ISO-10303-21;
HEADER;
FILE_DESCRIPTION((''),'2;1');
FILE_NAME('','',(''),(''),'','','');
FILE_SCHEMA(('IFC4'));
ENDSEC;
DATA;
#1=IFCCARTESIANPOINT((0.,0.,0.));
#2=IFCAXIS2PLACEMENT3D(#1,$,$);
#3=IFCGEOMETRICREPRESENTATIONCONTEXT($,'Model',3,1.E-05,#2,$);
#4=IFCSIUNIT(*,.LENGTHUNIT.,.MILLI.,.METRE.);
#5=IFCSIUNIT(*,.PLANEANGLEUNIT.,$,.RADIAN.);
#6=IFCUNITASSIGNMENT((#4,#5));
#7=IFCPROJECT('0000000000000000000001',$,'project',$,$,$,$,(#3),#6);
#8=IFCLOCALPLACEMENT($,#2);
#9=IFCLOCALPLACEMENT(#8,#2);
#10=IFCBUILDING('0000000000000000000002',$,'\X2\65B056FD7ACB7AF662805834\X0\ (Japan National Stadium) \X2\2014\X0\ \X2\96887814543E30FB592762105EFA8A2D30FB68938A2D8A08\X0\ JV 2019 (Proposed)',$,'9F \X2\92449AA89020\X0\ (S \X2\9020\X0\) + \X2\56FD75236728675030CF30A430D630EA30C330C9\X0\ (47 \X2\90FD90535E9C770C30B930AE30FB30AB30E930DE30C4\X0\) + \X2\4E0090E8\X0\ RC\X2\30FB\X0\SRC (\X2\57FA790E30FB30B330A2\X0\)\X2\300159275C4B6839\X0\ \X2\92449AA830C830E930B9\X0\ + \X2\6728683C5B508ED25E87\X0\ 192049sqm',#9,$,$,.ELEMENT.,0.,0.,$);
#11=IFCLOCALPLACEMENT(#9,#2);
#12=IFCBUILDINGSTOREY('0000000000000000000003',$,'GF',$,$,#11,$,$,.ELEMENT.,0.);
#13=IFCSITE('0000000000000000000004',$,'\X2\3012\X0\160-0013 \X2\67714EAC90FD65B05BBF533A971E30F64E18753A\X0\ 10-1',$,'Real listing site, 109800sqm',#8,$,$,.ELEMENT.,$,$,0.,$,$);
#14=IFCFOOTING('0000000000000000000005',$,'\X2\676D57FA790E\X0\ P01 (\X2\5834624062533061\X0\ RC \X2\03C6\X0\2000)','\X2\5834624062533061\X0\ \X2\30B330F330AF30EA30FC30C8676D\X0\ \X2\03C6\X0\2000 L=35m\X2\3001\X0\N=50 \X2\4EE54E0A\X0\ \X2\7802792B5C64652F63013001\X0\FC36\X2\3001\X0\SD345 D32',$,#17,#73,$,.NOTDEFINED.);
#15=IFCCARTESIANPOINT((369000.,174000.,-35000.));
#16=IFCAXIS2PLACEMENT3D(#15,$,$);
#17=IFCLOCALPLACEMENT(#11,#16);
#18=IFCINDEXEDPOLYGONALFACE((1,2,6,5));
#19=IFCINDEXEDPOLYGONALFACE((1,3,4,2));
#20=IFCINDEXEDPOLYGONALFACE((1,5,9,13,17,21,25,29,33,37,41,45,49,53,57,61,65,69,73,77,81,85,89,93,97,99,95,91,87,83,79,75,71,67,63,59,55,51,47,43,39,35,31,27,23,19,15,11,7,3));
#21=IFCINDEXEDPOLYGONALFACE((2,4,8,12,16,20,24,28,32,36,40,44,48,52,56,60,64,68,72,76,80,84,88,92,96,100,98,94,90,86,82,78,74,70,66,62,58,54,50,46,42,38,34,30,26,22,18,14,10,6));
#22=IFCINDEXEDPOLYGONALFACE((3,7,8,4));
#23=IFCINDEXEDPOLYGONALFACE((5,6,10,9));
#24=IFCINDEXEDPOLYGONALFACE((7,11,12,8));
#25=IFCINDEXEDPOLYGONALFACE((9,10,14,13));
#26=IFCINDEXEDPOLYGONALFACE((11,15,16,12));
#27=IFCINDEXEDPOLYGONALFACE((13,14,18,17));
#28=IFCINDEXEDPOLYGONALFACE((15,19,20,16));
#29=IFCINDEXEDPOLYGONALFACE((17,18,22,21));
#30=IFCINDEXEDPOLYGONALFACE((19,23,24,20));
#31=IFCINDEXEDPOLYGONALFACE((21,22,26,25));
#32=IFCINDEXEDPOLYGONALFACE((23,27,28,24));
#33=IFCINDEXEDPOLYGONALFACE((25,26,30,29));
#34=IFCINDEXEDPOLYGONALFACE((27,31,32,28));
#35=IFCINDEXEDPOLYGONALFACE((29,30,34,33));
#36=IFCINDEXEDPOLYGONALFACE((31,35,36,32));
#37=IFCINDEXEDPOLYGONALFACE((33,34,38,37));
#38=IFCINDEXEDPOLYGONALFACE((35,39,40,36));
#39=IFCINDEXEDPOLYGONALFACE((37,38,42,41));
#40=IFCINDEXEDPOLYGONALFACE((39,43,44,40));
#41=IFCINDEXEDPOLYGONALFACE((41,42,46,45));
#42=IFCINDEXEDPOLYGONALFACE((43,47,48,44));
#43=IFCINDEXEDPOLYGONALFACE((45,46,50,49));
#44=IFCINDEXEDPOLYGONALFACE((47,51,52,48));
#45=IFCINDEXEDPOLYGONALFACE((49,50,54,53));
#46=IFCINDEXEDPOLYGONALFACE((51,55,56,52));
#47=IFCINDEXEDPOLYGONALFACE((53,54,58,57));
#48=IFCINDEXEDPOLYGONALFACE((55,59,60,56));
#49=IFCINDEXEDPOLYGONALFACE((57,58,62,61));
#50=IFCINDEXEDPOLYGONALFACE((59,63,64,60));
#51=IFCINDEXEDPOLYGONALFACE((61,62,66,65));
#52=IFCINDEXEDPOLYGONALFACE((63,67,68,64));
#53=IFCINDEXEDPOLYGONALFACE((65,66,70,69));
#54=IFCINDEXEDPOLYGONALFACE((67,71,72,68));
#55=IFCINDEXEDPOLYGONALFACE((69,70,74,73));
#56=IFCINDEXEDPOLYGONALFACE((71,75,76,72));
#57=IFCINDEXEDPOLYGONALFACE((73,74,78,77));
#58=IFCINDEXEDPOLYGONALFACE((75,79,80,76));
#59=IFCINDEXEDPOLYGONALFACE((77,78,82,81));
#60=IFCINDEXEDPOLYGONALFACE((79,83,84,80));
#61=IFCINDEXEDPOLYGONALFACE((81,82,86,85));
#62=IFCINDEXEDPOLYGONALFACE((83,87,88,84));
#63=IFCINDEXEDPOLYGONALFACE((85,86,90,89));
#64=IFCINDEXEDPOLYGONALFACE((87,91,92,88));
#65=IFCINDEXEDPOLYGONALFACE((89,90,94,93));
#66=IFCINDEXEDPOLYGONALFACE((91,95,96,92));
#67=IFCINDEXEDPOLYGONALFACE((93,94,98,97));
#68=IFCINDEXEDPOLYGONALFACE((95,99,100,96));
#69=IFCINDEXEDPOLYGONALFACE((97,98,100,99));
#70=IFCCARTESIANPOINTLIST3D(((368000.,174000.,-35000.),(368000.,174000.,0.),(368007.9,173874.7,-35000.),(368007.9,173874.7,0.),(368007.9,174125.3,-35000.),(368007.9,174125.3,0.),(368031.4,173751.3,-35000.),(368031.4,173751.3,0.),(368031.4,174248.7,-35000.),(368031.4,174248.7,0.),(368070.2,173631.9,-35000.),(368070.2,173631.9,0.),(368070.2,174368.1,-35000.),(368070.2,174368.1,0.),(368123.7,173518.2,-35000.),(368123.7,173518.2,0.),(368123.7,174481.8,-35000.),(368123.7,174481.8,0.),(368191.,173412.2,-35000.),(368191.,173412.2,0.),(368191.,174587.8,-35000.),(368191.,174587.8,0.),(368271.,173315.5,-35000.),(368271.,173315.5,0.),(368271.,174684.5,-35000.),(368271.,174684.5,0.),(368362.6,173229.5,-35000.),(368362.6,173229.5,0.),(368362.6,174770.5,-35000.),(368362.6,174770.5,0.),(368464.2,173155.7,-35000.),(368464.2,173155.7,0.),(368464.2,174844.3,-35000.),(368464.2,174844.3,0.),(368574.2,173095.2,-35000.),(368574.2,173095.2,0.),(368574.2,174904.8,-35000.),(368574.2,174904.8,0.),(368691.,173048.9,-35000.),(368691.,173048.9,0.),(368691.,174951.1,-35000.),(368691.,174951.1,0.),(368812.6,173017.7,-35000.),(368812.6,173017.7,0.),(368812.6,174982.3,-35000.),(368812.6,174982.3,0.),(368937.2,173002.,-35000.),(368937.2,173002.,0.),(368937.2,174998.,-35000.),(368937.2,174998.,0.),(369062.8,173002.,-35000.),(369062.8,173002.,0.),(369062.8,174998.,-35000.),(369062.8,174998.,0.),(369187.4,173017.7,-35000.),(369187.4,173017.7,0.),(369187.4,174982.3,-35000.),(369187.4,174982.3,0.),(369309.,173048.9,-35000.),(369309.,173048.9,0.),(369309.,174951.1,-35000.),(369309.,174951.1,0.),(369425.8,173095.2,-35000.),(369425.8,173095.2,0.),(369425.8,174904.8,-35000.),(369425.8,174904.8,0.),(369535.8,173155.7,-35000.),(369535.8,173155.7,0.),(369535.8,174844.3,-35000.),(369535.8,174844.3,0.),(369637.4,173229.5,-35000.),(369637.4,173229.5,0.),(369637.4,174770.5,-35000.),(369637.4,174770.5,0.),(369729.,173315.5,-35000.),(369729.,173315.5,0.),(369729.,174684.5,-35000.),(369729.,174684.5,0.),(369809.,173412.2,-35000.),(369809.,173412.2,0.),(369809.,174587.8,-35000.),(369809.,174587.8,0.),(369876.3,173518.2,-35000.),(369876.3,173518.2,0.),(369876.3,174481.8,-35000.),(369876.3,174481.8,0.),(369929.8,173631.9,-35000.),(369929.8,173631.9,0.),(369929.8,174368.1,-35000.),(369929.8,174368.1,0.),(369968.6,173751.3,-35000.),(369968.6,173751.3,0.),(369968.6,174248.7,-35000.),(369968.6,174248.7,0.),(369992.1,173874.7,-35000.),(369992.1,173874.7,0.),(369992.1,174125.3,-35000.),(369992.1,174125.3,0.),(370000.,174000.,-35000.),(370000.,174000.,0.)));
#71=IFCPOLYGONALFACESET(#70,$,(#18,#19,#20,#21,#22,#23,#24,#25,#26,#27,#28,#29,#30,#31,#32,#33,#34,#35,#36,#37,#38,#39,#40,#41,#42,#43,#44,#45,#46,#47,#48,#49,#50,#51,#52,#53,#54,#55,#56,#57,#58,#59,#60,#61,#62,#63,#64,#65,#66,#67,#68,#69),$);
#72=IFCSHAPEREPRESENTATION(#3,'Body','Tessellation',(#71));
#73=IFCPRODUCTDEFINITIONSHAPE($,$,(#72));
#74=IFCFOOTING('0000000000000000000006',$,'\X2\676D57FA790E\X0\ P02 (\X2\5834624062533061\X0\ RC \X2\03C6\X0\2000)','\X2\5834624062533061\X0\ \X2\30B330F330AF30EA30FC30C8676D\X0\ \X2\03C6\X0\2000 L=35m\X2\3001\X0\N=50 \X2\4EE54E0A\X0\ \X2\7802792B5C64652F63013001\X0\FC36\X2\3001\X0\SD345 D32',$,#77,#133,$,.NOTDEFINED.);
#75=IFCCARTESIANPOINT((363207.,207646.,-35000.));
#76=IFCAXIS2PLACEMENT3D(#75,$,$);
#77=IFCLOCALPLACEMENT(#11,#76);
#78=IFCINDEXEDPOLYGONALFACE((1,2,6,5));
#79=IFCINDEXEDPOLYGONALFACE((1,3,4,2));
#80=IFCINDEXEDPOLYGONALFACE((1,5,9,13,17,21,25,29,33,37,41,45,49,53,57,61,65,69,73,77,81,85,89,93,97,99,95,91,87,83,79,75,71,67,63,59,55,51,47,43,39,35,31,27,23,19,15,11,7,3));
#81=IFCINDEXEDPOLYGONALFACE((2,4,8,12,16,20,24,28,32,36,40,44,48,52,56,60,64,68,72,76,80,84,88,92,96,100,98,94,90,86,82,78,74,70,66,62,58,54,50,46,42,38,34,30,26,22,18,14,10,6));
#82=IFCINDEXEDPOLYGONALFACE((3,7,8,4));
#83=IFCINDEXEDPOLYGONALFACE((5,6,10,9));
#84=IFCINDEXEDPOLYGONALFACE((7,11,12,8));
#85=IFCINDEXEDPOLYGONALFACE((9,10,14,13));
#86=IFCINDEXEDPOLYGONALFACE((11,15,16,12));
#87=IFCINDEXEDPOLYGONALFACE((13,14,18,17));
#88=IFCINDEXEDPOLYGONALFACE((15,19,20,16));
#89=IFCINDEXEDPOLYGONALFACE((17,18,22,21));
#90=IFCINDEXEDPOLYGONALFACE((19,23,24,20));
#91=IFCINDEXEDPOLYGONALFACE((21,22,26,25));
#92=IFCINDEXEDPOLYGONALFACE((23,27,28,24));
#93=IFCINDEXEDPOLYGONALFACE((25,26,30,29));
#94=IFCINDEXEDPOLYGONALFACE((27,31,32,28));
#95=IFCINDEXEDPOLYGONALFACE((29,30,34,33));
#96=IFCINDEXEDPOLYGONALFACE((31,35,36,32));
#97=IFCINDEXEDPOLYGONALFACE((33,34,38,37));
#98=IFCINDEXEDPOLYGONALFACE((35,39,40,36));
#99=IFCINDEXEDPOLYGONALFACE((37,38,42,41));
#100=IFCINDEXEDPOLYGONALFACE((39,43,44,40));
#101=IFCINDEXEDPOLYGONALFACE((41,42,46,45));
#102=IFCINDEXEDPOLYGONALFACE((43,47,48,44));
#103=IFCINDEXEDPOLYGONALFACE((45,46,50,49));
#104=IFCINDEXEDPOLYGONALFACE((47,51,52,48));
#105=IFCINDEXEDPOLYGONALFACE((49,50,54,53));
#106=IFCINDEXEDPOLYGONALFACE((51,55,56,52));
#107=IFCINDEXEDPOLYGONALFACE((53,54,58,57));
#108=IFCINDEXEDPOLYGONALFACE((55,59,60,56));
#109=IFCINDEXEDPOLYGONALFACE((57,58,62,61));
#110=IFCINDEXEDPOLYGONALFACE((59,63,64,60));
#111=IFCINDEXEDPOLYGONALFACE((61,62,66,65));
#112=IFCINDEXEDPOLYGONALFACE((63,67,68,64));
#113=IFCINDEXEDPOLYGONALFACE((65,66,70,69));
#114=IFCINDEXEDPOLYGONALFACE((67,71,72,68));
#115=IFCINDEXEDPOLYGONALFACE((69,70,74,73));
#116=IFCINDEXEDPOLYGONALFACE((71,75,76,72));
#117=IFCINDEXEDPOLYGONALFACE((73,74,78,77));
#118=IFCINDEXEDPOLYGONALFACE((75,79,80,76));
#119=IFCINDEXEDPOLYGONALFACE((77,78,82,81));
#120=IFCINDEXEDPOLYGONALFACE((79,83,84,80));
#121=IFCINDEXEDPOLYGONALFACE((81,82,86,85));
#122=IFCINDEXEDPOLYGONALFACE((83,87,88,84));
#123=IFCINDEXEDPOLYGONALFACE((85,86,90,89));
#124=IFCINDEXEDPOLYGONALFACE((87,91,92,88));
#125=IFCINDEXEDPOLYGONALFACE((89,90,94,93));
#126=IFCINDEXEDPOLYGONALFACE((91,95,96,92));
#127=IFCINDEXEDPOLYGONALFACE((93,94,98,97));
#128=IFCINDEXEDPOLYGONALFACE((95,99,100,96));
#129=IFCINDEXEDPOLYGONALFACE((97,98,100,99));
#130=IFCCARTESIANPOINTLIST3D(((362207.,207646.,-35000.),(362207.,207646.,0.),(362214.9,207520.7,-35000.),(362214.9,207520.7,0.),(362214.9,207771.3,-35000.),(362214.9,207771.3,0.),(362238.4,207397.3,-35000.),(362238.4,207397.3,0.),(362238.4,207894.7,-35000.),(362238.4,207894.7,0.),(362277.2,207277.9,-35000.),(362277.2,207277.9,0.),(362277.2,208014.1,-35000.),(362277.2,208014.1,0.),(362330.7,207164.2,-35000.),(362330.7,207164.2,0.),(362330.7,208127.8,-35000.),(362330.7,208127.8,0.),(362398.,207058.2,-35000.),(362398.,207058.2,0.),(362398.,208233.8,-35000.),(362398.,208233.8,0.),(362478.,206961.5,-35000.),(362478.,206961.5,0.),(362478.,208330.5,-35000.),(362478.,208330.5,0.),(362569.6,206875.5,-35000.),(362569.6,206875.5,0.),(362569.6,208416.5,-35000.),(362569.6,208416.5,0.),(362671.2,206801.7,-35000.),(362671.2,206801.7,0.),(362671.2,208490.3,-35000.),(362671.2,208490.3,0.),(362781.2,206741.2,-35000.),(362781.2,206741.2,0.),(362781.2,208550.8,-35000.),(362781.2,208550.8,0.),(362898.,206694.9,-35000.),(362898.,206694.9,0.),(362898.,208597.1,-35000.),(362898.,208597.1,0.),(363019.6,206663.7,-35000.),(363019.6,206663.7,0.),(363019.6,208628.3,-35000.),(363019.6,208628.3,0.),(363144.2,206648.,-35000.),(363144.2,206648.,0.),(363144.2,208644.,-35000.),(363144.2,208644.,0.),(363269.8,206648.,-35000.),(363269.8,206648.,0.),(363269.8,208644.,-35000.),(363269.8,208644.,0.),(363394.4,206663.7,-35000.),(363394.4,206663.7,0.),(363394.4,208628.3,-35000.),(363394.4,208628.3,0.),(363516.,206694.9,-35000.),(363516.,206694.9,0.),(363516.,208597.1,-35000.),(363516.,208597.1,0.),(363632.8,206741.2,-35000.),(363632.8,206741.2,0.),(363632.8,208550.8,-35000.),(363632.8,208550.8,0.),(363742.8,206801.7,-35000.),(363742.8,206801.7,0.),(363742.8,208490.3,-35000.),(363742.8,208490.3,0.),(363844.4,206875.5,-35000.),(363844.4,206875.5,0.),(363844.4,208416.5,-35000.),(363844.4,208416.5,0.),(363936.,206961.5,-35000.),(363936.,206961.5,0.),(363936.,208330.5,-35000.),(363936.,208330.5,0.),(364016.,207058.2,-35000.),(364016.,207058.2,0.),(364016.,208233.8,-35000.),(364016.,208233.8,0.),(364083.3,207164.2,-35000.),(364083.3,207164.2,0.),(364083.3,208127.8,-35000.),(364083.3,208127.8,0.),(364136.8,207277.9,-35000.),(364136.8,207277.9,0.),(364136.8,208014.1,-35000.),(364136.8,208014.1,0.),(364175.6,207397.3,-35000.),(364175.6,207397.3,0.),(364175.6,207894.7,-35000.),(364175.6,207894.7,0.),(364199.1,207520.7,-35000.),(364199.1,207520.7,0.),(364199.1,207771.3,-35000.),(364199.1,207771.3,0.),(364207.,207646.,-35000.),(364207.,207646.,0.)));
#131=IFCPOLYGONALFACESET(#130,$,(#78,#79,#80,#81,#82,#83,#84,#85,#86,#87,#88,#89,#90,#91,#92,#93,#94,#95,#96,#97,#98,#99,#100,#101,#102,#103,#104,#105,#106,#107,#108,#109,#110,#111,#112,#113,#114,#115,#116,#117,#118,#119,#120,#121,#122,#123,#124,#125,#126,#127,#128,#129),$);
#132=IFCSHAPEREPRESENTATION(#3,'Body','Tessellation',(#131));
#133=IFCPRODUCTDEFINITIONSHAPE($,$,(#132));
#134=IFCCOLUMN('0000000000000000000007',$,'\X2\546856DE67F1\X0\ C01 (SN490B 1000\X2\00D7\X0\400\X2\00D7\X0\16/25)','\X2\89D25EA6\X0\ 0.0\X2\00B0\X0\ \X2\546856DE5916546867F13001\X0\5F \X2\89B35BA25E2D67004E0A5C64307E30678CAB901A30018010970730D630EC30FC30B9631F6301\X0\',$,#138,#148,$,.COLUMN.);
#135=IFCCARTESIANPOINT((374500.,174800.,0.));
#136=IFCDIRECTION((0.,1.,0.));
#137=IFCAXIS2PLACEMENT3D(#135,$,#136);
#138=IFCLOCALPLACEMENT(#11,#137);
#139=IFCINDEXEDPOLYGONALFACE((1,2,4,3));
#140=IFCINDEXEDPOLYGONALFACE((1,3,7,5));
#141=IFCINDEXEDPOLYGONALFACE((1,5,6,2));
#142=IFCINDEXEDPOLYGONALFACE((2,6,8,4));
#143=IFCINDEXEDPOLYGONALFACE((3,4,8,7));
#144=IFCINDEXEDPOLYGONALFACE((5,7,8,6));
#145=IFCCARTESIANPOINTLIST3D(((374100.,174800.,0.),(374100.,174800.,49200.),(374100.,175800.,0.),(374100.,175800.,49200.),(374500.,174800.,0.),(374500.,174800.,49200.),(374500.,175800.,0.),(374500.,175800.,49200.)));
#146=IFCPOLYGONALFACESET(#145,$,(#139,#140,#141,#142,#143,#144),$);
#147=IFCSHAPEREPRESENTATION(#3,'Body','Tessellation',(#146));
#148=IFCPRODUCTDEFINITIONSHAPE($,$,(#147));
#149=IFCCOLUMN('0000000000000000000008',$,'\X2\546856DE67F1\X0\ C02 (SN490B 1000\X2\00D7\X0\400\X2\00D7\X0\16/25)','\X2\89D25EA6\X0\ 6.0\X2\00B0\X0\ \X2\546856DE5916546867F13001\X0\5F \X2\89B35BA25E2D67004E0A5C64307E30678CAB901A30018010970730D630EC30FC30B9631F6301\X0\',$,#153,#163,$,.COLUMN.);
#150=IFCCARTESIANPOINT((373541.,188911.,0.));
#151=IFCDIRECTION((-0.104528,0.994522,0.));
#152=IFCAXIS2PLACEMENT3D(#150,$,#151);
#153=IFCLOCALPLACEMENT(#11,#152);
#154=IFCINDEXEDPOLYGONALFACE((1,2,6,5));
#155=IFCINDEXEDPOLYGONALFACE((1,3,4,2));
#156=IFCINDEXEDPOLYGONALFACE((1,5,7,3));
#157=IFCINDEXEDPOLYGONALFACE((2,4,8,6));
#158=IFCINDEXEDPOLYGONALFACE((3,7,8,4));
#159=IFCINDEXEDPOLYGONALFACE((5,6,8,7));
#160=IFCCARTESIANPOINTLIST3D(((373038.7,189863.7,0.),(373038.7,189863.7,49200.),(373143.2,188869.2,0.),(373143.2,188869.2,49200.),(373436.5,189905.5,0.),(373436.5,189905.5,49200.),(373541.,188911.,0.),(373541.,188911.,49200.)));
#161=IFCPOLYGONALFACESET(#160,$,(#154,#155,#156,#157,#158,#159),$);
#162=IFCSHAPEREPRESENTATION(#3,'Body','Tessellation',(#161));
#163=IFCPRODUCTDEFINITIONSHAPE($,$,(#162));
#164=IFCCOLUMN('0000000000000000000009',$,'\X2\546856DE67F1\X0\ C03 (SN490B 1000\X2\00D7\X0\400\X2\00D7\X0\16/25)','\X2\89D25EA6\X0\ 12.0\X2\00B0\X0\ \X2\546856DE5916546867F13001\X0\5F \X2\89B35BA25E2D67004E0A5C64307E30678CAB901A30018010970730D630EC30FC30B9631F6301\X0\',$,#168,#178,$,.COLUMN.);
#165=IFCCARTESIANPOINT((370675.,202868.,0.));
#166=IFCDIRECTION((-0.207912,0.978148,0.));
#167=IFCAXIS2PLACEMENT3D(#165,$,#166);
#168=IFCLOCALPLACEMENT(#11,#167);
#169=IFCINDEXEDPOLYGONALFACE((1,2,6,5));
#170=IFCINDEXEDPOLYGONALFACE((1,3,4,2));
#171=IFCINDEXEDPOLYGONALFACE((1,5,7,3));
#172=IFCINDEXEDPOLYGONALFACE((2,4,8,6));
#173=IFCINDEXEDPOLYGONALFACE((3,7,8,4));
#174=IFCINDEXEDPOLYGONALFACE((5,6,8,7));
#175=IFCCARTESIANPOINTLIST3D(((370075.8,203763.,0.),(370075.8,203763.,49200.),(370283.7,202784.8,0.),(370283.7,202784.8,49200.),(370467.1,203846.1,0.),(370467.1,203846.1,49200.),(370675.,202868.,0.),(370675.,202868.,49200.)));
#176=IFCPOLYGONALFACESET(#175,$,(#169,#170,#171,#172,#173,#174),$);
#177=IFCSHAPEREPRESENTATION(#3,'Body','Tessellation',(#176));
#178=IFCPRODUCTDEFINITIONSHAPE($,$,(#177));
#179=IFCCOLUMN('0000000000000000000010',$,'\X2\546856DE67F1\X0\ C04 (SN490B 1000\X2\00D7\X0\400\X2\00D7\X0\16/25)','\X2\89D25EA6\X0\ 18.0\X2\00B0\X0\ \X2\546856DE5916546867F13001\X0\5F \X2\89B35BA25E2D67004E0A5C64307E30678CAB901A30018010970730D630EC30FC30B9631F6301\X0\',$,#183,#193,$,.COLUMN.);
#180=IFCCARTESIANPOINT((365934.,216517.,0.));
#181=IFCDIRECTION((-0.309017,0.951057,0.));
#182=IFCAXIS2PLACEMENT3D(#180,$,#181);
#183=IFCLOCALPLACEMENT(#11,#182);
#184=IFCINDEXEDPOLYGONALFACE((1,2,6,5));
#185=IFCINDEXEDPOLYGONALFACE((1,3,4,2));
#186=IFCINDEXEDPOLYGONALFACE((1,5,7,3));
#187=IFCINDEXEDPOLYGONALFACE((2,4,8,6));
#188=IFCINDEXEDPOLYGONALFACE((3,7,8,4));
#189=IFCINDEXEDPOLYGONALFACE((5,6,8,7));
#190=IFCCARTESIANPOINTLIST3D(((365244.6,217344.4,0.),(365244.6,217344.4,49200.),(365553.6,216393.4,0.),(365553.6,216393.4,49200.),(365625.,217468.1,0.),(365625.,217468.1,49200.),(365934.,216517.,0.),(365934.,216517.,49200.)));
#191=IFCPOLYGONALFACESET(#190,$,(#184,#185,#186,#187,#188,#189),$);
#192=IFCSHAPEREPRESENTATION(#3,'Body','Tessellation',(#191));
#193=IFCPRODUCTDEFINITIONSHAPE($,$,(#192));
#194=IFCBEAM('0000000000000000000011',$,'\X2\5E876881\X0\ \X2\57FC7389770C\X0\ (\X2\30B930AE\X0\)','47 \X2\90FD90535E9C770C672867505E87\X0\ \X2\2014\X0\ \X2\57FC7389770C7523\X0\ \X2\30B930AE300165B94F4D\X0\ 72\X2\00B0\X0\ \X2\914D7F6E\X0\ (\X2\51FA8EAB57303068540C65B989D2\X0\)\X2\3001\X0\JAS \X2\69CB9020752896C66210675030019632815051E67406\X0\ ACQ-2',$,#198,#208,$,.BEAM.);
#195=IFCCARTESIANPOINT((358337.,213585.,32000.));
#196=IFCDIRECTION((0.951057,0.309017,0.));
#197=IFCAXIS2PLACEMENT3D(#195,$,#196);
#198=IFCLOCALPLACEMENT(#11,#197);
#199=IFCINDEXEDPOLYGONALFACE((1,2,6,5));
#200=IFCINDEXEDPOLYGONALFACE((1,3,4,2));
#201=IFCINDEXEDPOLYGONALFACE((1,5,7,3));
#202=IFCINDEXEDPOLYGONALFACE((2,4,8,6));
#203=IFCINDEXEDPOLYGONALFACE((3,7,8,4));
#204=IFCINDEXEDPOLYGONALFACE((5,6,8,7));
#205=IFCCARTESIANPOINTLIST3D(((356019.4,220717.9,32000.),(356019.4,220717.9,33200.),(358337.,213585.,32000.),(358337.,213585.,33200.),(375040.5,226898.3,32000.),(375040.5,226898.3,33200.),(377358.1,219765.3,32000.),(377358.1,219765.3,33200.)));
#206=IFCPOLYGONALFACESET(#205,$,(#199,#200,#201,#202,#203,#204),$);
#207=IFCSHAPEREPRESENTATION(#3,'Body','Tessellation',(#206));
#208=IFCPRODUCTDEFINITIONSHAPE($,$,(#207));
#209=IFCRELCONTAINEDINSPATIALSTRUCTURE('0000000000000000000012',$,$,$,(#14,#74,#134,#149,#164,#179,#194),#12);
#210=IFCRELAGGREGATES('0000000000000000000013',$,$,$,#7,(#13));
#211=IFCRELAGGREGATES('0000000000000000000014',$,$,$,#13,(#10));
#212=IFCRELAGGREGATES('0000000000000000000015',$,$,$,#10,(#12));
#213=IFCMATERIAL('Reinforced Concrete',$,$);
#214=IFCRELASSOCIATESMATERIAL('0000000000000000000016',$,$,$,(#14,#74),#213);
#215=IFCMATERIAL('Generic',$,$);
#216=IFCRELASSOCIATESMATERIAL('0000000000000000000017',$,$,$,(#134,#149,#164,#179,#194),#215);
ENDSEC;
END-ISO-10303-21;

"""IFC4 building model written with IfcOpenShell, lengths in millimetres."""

from ifc_helpers import new_model, si_unit, frame, frame_2d, origin, origin_2d, place, context, project, spatial, rectangle, circle, extrude, material, element, save


model = new_model("IFC4")

# Units and contexts
model_context = context("Model", 3, precision=1e-05, world=origin())
ifc_project = project(units=[si_unit("LENGTHUNIT", "METRE", prefix="MILLI"), si_unit("PLANEANGLEUNIT", "RADIAN")], contexts=[model_context])

# Site, building, storey
site_placement = place(None, origin())
site = spatial("IfcSite", under=ifc_project, at=site_placement, Name="〒160-0013 東京都新宿区霞ヶ丘町 10-1", ObjectType="Real listing site, 109800sqm", CompositionType="ELEMENT", RefElevation=0.0)
building_placement = place(site_placement, origin())
building = spatial("IfcBuilding", under=site, at=building_placement, Name="新国立競技場 (Japan National Stadium) — 隈研吾・大成建設・梓設計 JV 2019 (Proposed)", ObjectType="9F 鉄骨造 (S 造) + 国産木材ハイブリッド (47 都道府県スギ・カラマツ) + 一部 RC・SRC (基礎・コア)、大屋根 鉄骨トラス + 木格子軒庇 192049sqm", CompositionType="ELEMENT", ElevationOfRefHeight=0.0, ElevationOfTerrain=0.0)
storey_placement = place(building_placement, origin())
storey = spatial("IfcBuildingStorey", under=building, at=storey_placement, Name="GF", CompositionType="ELEMENT", Elevation=0.0)

# Footings
ifc_material_1 = material(Name="Reinforced Concrete")
footing_1_placement = place(storey_placement, frame((369000.0, 174000.0, -35000.0)))
element("IfcFooting", 1, at=footing_1_placement, inside=storey, material=ifc_material_1, Name="杭基礎 P01 (場所打ち RC φ2000)", Description="場所打ち コンクリート杭 φ2000 L=35m、N=50 以上 砂礫層支持、FC36、SD345 D32", PredefinedType="NOTDEFINED", context=model_context, shape_type="SweptSolid", body=[
    extrude(circle(Radius=1000.0, at=origin_2d()), frame((369000.0, 174000.0, -35000.0)), (0.0, 0.0, 1.0), 35000.0),
])
footing_2_placement = place(storey_placement, frame((363207.0, 207646.0, -35000.0)))
element("IfcFooting", 2, at=footing_2_placement, inside=storey, material=ifc_material_1, Name="杭基礎 P02 (場所打ち RC φ2000)", Description="場所打ち コンクリート杭 φ2000 L=35m、N=50 以上 砂礫層支持、FC36、SD345 D32", PredefinedType="NOTDEFINED", context=model_context, shape_type="SweptSolid", body=[
    extrude(circle(Radius=1000.0, at=origin_2d()), frame((363207.0, 207646.0, -35000.0)), (0.0, 0.0, 1.0), 35000.0),
])

# Columns
ifc_material_2 = material(Name="Generic")
column_1_placement = place(storey_placement, frame((374500.0, 174800.0, 0.0), x_axis=(0.0, 1.0, 0.0)))
element("IfcColumn", 3, at=column_1_placement, inside=storey, material=ifc_material_2, Name="周回柱 C01 (SN490B 1000×400×16/25)", Description="角度 0.0° 周回外周柱、5F 観客席最上層まで貫通、耐震ブレース挟持", PredefinedType="COLUMN", context=model_context, shape_type="SweptSolid", body=[
    extrude(rectangle(XDim=1000.0, YDim=400.0, at=frame_2d((500.0, 200.0))), frame((374500.0, 174800.0, 0.0), x_axis=(0.0, 1.0, 0.0)), (0.0, 0.0, 1.0), 49200.0),
])
column_2_placement = place(storey_placement, frame((373541.0, 188911.0, 0.0), x_axis=(-0.104528, 0.994522, 0.0)))
element("IfcColumn", 4, at=column_2_placement, inside=storey, material=ifc_material_2, Name="周回柱 C02 (SN490B 1000×400×16/25)", Description="角度 6.0° 周回外周柱、5F 観客席最上層まで貫通、耐震ブレース挟持", PredefinedType="COLUMN", context=model_context, shape_type="SweptSolid", body=[
    extrude(rectangle(XDim=1000.0, YDim=400.0, at=frame_2d((500.0, 200.0))), frame((373541.0, 188911.0, 0.0), x_axis=(-0.104528, 0.994522, 0.0)), (0.0, 0.0, 1.0), 49200.0),
])
column_3_placement = place(storey_placement, frame((370675.0, 202868.0, 0.0), x_axis=(-0.207912, 0.978148, 0.0)))
element("IfcColumn", 5, at=column_3_placement, inside=storey, material=ifc_material_2, Name="周回柱 C03 (SN490B 1000×400×16/25)", Description="角度 12.0° 周回外周柱、5F 観客席最上層まで貫通、耐震ブレース挟持", PredefinedType="COLUMN", context=model_context, shape_type="SweptSolid", body=[
    extrude(rectangle(XDim=1000.0, YDim=400.0, at=frame_2d((500.0, 200.0))), frame((370675.0, 202868.0, 0.0), x_axis=(-0.207912, 0.978148, 0.0)), (0.0, 0.0, 1.0), 49200.0),
])
column_4_placement = place(storey_placement, frame((365934.0, 216517.0, 0.0), x_axis=(-0.309017, 0.951057, 0.0)))
element("IfcColumn", 6, at=column_4_placement, inside=storey, material=ifc_material_2, Name="周回柱 C04 (SN490B 1000×400×16/25)", Description="角度 18.0° 周回外周柱、5F 観客席最上層まで貫通、耐震ブレース挟持", PredefinedType="COLUMN", context=model_context, shape_type="SweptSolid", body=[
    extrude(rectangle(XDim=1000.0, YDim=400.0, at=frame_2d((500.0, 200.0))), frame((365934.0, 216517.0, 0.0), x_axis=(-0.309017, 0.951057, 0.0)), (0.0, 0.0, 1.0), 49200.0),
])

# Beam
beam_1_placement = place(storey_placement, frame((358337.0, 213585.0, 32000.0), x_axis=(0.951057, 0.309017, 0.0)))
element("IfcBeam", 7, at=beam_1_placement, inside=storey, material=ifc_material_2, Name="庇梁 埼玉県 (スギ)", Description="47 都道府県木材庇 — 埼玉県産 スギ、方位 72° 配置 (出身地と同方角)、JAS 構造用集成材、防腐処理 ACQ-2", PredefinedType="BEAM", context=model_context, shape_type="SweptSolid", body=[
    extrude(rectangle(XDim=20000.0, YDim=7500.0, at=frame_2d((10000.0, 3750.0))), frame((358337.0, 213585.0, 32000.0), x_axis=(0.951057, 0.309017, 0.0)), (0.0, 0.0, 1.0), 1200.0),
])

save(model, "model.ifc")
